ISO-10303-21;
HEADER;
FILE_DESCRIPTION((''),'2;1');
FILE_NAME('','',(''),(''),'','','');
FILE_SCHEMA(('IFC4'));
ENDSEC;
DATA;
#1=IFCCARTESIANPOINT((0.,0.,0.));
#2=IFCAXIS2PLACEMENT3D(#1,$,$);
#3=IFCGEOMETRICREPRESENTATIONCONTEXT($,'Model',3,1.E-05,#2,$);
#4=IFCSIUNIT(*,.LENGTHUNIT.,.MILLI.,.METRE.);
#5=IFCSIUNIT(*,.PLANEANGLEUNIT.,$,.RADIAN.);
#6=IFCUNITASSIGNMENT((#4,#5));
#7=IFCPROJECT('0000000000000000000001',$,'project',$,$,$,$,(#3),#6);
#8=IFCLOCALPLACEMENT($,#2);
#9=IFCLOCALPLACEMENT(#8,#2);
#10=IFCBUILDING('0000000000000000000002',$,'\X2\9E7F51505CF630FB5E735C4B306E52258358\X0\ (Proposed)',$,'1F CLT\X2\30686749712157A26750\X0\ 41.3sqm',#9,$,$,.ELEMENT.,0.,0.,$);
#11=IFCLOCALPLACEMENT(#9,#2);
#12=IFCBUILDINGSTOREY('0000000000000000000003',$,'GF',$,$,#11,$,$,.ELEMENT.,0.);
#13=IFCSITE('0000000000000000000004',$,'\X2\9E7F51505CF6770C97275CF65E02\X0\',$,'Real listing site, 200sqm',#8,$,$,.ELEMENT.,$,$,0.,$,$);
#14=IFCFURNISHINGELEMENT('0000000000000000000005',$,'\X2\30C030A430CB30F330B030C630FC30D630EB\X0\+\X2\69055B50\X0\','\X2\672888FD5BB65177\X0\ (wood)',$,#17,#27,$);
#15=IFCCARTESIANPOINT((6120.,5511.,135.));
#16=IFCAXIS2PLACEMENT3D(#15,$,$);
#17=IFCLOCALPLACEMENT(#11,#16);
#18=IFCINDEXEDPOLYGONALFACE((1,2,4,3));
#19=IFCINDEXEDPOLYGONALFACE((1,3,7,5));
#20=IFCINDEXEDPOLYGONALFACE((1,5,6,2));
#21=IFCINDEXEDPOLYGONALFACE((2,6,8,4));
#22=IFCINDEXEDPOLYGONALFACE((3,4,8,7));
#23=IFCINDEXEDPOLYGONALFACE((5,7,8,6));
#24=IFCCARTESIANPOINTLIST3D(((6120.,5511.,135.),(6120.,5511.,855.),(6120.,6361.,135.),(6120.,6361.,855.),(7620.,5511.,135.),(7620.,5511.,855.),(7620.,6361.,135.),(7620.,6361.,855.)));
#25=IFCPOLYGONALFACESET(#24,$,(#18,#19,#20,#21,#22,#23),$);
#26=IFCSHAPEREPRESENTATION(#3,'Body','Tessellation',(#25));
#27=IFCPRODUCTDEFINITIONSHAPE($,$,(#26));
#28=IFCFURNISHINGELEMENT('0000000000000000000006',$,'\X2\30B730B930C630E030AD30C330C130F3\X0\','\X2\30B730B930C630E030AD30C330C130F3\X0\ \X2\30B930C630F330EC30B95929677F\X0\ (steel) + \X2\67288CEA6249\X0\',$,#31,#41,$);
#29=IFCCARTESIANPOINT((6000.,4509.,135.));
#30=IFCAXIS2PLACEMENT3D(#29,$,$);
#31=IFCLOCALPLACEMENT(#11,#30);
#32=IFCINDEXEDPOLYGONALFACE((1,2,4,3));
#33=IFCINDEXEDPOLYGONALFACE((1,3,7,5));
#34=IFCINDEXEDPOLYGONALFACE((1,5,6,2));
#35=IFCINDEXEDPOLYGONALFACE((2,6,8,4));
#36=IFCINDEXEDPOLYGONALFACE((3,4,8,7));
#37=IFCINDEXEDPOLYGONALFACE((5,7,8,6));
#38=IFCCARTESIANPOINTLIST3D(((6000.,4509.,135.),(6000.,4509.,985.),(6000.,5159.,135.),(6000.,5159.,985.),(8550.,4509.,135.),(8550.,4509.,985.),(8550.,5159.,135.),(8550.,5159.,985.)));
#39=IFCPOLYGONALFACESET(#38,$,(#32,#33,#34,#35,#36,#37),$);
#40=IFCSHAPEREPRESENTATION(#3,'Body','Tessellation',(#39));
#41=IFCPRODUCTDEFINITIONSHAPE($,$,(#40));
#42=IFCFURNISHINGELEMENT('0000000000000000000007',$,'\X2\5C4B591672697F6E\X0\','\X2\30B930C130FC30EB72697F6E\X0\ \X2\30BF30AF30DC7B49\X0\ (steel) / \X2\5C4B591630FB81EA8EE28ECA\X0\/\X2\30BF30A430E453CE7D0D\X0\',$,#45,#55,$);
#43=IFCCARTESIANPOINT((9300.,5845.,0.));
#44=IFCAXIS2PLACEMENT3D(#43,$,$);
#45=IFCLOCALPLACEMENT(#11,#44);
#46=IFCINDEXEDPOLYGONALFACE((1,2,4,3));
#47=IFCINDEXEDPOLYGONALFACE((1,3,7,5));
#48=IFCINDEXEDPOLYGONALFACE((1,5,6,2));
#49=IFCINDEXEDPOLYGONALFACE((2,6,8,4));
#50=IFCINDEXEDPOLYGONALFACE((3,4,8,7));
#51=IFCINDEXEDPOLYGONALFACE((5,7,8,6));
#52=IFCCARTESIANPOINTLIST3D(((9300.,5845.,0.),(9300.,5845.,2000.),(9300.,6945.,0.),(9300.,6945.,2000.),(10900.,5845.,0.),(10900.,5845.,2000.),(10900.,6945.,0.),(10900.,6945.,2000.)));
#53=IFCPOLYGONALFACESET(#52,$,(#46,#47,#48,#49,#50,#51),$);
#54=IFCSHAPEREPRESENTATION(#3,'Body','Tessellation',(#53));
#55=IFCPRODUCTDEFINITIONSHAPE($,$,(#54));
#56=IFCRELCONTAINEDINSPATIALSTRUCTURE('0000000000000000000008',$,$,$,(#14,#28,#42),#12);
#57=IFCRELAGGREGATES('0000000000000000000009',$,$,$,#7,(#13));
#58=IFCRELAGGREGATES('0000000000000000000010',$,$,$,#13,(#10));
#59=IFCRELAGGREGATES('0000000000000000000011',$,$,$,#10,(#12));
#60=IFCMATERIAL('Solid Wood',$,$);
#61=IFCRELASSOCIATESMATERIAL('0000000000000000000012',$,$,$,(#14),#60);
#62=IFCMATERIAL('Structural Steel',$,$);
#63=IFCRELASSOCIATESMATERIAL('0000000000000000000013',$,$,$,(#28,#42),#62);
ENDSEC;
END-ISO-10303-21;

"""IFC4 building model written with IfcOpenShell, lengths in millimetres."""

from ifc_helpers import new_model, si_unit, frame, frame_2d, origin, place, context, project, spatial, rectangle, extrude, material, element, save


model = new_model("IFC4")

# Units and contexts
model_context = context("Model", 3, precision=1e-05, world=origin())
ifc_project = project(units=[si_unit("LENGTHUNIT", "METRE", prefix="MILLI"), si_unit("PLANEANGLEUNIT", "RADIAN")], contexts=[model_context])

# Site, building, storey
site_placement = place(None, origin())
site = spatial("IfcSite", under=ifc_project, at=site_placement, Name="鹿児島県霧島市", ObjectType="Real listing site, 200sqm", CompositionType="ELEMENT", RefElevation=0.0)
building_placement = place(site_placement, origin())
building = spatial("IfcBuilding", under=site, at=building_placement, Name="鹿児島・平屋の別荘 (Proposed)", ObjectType="1F CLTと杉無垢材 41.3sqm", CompositionType="ELEMENT", ElevationOfRefHeight=0.0, ElevationOfTerrain=0.0)
storey_placement = place(building_placement, origin())
storey = spatial("IfcBuildingStorey", under=building, at=storey_placement, Name="GF", CompositionType="ELEMENT", Elevation=0.0)

# Shared definitions
ifc_material_1 = material(Name="Solid Wood")

# Shared definitions
ifc_material_2 = material(Name="Structural Steel")

# Furnishing elements
furnishing_1_placement = place(storey_placement, frame((6120.0, 5511.0, 135.0)))
element("IfcFurnishingElement", 1, at=furnishing_1_placement, inside=storey, material=ifc_material_1, Name="ダイニングテーブル+椅子", Description="木製家具 (wood)", context=model_context, shape_type="SweptSolid", body=[
    extrude(rectangle(XDim=1500.0, YDim=850.0, at=frame_2d((750.0, 425.0))), frame((6120.0, 5511.0, 135.0)), (0.0, 0.0, 1.0), 720.0),
])
furnishing_2_placement = place(storey_placement, frame((6000.0, 4509.0, 135.0)))
element("IfcFurnishingElement", 2, at=furnishing_2_placement, inside=storey, material=ifc_material_2, Name="システムキッチン", Description="システムキッチン ステンレス天板 (steel) + 木質扉", context=model_context, shape_type="SweptSolid", body=[
    extrude(rectangle(XDim=2550.0, YDim=650.0, at=frame_2d((1275.0, 325.0))), frame((6000.0, 4509.0, 135.0)), (0.0, 0.0, 1.0), 850.0),
])
furnishing_3_placement = place(storey_placement, frame((9300.0, 5845.0, 0.0)))
element("IfcFurnishingElement", 3, at=furnishing_3_placement, inside=storey, material=ifc_material_2, Name="屋外物置", Description="スチール物置 タクボ等 (steel) / 屋外・自転車/タイヤ収納", context=model_context, shape_type="SweptSolid", body=[
    extrude(rectangle(XDim=1600.0, YDim=1100.0, at=frame_2d((800.0, 550.0))), frame((9300.0, 5845.0, 0.0)), (0.0, 0.0, 1.0), 2000.0),
])

save(model, "model.ifc")
